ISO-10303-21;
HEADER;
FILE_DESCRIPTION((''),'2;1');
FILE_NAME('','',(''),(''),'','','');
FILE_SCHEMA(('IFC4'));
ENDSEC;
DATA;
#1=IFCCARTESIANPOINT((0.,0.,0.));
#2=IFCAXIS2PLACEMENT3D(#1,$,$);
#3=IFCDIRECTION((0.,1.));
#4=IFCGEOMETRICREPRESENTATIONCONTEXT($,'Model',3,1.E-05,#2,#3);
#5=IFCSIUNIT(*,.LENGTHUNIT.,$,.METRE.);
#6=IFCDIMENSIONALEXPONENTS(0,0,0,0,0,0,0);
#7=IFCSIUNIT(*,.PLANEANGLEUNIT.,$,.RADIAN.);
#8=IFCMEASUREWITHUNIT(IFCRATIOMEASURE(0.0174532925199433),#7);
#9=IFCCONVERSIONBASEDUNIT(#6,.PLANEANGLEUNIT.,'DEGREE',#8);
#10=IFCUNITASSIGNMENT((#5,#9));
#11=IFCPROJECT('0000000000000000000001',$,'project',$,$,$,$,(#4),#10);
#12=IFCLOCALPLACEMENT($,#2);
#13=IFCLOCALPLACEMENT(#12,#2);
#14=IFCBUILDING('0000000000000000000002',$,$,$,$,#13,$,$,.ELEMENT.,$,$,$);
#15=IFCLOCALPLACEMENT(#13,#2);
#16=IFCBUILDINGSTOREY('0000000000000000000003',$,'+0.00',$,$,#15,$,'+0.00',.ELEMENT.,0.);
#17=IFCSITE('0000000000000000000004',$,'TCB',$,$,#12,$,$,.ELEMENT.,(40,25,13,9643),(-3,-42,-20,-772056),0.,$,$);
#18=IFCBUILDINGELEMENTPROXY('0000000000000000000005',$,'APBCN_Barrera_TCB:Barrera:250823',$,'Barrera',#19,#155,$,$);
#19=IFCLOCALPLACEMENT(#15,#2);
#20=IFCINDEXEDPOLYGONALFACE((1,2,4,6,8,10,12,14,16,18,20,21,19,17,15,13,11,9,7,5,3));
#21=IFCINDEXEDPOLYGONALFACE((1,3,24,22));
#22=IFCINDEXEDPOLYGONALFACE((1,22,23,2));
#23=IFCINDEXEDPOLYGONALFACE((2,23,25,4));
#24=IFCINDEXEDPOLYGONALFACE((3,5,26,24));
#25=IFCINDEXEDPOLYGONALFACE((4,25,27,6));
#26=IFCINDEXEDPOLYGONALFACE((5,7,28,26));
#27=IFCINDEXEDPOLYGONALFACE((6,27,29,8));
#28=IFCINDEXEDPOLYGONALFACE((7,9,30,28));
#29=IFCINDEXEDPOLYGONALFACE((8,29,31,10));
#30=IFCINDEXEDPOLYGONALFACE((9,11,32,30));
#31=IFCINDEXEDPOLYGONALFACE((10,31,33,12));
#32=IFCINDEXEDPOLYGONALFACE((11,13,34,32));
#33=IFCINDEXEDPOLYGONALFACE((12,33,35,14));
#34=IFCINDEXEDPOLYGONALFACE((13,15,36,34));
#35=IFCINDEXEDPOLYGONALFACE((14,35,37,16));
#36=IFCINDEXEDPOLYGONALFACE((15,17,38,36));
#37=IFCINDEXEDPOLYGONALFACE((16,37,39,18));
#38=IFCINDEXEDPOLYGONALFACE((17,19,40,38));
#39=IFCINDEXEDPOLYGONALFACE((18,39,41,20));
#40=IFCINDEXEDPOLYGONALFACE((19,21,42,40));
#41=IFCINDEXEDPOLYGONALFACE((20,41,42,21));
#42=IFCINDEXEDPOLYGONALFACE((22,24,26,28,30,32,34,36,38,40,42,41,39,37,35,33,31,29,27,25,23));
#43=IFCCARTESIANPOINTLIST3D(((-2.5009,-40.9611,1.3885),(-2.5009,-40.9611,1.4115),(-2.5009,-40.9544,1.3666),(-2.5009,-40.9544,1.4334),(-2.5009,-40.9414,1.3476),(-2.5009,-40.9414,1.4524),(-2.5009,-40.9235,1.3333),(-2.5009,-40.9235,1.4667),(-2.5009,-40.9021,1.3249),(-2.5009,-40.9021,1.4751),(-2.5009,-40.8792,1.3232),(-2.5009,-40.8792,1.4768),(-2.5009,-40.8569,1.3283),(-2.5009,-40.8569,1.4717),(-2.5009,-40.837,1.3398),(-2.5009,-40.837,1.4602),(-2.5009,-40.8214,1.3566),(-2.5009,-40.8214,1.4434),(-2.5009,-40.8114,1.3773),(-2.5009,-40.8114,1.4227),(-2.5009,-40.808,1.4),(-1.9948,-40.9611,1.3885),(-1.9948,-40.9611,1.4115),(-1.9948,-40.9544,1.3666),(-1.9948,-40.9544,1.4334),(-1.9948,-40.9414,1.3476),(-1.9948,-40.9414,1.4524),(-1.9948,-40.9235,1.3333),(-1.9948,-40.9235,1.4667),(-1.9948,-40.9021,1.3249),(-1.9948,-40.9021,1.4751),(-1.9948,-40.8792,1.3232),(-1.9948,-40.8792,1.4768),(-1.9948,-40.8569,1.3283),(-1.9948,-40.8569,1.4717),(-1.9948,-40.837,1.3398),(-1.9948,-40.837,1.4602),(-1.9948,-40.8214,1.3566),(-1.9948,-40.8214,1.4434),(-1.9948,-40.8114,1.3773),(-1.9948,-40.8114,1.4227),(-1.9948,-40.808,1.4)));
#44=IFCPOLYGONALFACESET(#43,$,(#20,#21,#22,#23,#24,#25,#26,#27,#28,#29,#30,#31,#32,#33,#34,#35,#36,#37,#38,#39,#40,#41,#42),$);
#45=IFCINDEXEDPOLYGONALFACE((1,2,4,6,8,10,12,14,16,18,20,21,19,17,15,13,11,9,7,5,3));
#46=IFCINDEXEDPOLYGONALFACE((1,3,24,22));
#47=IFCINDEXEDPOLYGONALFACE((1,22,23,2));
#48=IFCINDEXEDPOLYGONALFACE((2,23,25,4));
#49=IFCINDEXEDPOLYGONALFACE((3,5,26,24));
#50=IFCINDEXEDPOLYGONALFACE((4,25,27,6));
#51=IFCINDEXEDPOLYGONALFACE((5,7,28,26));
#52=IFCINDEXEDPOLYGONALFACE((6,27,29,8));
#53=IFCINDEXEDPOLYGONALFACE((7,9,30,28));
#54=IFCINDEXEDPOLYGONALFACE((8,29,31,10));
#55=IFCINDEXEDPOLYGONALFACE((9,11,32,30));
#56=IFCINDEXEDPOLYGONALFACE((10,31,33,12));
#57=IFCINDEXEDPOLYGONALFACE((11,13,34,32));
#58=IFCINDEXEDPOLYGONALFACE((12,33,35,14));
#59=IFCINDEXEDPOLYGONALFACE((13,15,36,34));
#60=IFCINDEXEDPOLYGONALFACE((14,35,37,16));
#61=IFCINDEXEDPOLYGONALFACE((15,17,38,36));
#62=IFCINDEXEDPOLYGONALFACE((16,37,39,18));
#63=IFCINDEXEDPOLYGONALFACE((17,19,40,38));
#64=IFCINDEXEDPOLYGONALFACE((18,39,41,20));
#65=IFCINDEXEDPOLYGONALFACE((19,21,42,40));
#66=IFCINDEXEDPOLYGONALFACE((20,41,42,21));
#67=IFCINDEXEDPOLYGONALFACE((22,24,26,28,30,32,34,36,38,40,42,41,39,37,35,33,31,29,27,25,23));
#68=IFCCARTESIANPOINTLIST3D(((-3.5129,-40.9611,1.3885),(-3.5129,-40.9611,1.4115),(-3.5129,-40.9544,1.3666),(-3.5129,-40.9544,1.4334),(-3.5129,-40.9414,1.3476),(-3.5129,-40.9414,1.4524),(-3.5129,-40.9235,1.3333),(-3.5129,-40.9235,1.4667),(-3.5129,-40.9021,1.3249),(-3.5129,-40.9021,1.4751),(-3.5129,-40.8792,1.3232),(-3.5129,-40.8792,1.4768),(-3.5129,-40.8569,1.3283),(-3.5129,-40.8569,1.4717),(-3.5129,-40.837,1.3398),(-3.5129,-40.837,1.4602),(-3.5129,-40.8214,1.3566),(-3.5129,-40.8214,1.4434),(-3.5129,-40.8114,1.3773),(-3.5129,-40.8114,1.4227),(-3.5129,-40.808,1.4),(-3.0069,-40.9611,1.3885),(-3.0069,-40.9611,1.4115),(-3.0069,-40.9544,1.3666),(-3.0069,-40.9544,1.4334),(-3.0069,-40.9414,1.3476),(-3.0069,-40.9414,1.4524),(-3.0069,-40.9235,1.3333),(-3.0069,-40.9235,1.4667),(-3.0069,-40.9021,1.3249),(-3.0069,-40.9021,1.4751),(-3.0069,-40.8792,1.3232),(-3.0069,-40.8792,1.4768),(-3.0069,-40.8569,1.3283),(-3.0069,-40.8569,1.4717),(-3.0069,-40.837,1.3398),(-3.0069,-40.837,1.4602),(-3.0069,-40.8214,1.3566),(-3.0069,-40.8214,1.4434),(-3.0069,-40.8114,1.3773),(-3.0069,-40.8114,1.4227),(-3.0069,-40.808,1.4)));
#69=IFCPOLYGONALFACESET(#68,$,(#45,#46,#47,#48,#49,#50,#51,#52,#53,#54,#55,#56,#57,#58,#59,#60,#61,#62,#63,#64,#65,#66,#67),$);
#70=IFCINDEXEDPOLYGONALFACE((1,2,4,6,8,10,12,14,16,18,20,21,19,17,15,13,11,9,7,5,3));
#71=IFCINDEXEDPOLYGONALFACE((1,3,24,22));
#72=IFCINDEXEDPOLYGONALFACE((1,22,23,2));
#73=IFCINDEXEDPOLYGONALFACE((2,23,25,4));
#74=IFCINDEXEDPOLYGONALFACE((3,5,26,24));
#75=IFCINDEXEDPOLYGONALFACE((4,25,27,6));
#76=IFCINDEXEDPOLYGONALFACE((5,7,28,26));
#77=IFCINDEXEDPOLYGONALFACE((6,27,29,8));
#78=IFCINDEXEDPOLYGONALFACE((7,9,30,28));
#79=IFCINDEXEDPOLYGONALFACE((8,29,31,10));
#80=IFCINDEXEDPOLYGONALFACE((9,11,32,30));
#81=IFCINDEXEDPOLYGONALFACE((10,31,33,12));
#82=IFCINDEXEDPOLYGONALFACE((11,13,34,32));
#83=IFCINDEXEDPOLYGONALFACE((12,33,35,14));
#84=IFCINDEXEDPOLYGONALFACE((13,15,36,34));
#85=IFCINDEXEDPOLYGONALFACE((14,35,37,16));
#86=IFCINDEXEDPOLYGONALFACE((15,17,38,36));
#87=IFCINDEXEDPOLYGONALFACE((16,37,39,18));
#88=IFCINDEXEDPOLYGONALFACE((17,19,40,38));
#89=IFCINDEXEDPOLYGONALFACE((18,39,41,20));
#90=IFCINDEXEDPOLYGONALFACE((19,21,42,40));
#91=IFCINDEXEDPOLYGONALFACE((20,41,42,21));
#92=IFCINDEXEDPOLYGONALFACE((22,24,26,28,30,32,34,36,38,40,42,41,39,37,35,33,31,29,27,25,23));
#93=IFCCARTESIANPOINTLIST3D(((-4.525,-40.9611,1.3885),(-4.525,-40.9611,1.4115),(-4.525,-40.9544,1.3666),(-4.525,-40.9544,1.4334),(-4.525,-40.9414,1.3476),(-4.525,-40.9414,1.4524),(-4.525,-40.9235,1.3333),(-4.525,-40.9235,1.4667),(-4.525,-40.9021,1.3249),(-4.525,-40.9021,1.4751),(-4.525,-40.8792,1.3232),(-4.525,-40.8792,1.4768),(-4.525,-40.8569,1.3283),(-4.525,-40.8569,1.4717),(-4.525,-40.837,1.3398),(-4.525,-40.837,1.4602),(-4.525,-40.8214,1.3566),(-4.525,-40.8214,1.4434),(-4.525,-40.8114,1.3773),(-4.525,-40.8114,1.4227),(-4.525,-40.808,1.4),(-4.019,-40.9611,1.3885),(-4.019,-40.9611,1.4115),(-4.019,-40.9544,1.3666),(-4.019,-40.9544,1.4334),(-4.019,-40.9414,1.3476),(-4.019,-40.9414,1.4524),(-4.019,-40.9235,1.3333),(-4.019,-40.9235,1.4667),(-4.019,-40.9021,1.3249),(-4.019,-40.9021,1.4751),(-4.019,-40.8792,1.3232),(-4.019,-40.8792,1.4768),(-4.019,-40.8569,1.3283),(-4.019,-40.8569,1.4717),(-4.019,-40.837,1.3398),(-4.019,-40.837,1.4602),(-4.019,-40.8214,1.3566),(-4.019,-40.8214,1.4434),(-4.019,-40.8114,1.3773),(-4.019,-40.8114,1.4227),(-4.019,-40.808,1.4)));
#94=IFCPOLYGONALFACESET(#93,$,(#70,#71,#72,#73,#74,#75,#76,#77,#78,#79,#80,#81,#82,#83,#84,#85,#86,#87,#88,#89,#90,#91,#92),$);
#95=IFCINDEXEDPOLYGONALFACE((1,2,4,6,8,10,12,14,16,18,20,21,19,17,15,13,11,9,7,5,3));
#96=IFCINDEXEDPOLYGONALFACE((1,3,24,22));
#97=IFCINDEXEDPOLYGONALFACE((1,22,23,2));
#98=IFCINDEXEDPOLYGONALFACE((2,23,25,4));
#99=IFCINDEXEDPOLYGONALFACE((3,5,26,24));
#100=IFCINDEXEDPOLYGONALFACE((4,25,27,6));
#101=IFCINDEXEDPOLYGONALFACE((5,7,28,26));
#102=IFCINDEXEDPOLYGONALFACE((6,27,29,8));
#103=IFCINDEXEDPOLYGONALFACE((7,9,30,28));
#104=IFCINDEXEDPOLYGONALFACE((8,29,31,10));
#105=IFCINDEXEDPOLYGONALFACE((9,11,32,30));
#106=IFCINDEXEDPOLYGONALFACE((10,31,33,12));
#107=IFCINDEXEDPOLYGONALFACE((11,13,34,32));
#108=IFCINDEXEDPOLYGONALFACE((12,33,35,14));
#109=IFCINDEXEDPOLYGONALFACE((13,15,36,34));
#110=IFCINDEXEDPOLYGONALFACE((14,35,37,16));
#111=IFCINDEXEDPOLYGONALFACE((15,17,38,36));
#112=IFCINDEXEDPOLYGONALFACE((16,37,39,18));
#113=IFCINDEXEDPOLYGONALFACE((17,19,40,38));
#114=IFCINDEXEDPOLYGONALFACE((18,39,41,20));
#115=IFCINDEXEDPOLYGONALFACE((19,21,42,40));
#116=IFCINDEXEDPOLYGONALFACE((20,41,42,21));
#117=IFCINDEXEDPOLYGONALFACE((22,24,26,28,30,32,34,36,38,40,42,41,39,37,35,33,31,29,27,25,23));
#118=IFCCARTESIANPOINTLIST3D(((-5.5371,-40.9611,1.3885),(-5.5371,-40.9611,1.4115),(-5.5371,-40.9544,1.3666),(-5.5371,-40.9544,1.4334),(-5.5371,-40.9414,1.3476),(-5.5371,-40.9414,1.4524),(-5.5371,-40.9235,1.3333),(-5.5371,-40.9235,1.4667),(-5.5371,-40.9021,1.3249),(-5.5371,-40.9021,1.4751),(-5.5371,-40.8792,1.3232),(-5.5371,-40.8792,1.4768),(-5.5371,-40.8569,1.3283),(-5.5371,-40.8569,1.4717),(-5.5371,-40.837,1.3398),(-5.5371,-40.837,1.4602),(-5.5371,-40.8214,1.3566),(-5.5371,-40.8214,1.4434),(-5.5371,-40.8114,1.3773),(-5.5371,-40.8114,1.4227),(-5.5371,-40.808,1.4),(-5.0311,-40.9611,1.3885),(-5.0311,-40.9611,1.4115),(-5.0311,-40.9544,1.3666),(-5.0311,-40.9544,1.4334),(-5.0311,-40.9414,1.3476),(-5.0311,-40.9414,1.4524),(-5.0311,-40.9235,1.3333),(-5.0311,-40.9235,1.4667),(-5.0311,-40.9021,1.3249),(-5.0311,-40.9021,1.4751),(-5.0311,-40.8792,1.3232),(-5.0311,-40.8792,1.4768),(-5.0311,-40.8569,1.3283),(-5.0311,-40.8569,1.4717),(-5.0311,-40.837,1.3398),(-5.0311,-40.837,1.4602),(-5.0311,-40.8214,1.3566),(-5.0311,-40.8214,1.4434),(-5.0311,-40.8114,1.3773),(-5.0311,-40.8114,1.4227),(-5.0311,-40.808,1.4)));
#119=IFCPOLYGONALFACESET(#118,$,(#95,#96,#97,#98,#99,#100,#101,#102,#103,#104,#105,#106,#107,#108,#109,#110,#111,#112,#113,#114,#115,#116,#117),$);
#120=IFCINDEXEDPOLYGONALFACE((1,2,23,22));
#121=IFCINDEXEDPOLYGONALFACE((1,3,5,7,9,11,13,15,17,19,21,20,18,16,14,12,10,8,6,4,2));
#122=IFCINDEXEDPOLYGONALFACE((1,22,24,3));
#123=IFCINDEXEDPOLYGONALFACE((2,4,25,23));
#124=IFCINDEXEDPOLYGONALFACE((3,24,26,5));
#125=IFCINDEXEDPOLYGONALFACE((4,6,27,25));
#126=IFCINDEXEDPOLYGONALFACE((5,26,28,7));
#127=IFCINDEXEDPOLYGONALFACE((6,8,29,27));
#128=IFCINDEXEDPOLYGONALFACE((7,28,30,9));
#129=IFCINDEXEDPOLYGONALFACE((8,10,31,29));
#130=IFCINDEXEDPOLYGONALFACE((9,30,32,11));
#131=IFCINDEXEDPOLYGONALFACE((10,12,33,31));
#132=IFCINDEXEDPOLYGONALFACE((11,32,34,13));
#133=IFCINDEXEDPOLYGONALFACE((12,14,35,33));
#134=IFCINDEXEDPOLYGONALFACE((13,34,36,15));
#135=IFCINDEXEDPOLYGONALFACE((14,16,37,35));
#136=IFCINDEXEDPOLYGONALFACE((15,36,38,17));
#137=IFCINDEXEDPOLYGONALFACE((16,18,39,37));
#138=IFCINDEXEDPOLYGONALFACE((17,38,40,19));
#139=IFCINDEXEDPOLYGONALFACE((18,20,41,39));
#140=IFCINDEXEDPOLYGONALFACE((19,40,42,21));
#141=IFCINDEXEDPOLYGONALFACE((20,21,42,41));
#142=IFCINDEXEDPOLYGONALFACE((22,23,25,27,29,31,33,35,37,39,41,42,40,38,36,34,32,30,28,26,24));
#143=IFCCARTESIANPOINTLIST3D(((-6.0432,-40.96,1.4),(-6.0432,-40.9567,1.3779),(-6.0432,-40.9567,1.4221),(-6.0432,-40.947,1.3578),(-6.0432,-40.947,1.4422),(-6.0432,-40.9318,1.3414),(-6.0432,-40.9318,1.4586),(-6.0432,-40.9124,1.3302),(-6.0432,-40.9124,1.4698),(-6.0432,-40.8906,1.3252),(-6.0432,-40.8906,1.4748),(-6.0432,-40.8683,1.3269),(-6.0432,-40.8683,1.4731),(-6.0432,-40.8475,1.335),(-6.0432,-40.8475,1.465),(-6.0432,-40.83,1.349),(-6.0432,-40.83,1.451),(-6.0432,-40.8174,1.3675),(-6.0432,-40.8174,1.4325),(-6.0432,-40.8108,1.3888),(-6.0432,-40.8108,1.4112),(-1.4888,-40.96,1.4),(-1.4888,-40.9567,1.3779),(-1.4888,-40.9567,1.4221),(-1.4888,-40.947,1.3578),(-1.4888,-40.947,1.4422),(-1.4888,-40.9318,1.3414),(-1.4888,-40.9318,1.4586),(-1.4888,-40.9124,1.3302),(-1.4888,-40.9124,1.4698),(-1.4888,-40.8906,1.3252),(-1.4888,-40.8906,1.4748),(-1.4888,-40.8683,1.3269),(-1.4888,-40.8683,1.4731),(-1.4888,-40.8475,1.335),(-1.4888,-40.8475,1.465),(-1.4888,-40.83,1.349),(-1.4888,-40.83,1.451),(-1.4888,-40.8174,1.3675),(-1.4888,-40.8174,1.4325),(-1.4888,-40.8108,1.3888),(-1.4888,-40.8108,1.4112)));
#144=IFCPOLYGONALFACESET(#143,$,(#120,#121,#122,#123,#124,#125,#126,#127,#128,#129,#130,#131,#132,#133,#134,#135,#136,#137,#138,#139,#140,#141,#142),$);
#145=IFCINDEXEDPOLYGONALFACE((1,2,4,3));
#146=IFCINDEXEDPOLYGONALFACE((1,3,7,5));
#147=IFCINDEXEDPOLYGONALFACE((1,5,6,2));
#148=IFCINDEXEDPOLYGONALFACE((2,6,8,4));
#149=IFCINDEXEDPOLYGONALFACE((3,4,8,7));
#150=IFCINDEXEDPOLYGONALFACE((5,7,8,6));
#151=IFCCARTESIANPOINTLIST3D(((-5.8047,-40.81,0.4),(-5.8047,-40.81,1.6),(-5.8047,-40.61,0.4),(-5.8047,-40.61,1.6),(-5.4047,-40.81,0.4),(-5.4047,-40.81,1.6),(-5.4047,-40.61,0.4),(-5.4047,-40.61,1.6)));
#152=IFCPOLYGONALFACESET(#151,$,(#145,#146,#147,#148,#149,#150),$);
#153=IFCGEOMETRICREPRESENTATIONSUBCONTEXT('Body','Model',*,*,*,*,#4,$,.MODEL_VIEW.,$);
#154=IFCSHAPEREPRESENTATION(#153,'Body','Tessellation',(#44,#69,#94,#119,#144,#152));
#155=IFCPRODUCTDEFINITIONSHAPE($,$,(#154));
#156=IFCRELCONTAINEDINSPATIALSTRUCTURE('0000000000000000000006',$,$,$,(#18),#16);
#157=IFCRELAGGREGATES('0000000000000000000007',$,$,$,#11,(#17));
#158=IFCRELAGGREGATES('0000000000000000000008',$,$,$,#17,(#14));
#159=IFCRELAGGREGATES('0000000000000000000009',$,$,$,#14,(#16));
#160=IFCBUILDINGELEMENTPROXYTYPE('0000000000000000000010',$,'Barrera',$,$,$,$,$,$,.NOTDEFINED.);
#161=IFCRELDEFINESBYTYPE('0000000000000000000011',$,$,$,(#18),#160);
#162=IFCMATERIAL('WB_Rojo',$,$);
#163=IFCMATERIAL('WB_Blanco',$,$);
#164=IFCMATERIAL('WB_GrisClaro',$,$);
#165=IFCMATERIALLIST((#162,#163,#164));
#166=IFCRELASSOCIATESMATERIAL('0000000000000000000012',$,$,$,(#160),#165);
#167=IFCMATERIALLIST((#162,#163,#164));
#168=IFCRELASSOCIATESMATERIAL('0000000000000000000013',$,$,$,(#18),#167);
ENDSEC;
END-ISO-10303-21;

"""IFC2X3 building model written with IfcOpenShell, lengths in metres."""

from ifc_helpers import new_model, entity, si_unit, converted_unit, direction, frame, frame_2d, origin, place, context, subcontext, project, spatial, rectangle, circle, extrude, source, transform, mapped, material, material_list, type_object, type_shapes, element, save


model = new_model("IFC2X3")

# Units and contexts
model_context = context("Model", 3, precision=1e-05, world=origin(), true_north=direction((0.0, 1.0)))
body_context = subcontext(model_context, "Body", "Model", "MODEL_VIEW")
ifc_project = project(units=[si_unit("LENGTHUNIT", "METRE"), converted_unit("PLANEANGLEUNIT", "DEGREE", entity("IfcRatioMeasure", 0.0174532925199433), si_unit("PLANEANGLEUNIT", "RADIAN"), dimensions=[0, 0, 0, 0, 0, 0, 0])], contexts=[model_context])

# Site, building, storey
site_placement = place(None, origin())
site = spatial("IfcSite", under=ifc_project, at=site_placement, Name="TCB", CompositionType="ELEMENT", RefLatitude=(40, 25, 13, 9643), RefLongitude=(-3, -42, -20, -772056), RefElevation=0.0)
building_placement = place(site_placement, origin())
building = spatial("IfcBuilding", under=site, at=building_placement, CompositionType="ELEMENT")
storey_placement = place(building_placement, origin())
storey = spatial("IfcBuildingStorey", under=building, at=storey_placement, Name="+0.00", LongName="+0.00", CompositionType="ELEMENT", Elevation=0.0)

# Shared definitions
ifc_material_1 = material(Name="WB_GrisClaro")

# Building element proxy
ifc_material_2 = material(Name="WB_Rojo")
ifc_material_3 = material(Name="WB_Blanco")
ifc_material_list_1 = material_list([ifc_material_2, ifc_material_3, ifc_material_1])
building_element_proxy_type_1 = type_object("IfcBuildingElementProxyType", Name="Barrera", PredefinedType="NOTDEFINED", material=ifc_material_list_1)
shared_shape_1 = source(origin(), body_context, "Body", "SweptSolid", [
    extrude(circle(Radius=0.077, at=frame_2d((0.0, 0.0), x_axis=(1.0, 0.0))), frame((2.8039, -0.175, 1.0), z_axis=(1.0, 0.0, 0.0), x_axis=(0.0, 1.0, 0.0)), (0.0, 0.0, 1.0), 0.506),
    extrude(circle(Radius=0.077, at=frame_2d((0.0, 0.0), x_axis=(1.0, 0.0))), frame((1.7918, -0.175, 1.0), z_axis=(1.0, 0.0, 0.0), x_axis=(0.0, 1.0, 0.0)), (0.0, 0.0, 1.0), 0.506),
    extrude(circle(Radius=0.077, at=frame_2d((0.0, 0.0), x_axis=(1.0, 0.0))), frame((0.7797, -0.175, 1.0), z_axis=(1.0, 0.0, 0.0), x_axis=(0.0, 1.0, 0.0)), (0.0, 0.0, 1.0), 0.506),
    extrude(circle(Radius=0.077, at=frame_2d((0.0, 0.0), x_axis=(1.0, 0.0))), frame((-0.2324, -0.175, 1.0), z_axis=(1.0, 0.0, 0.0), x_axis=(0.0, 1.0, 0.0)), (0.0, 0.0, 1.0), 0.506),
    extrude(circle(Radius=0.075, at=frame_2d((0.0, 0.0), x_axis=(1.0, 0.0))), frame((-0.7385, -0.175, 1.0), z_axis=(1.0, 0.0, 0.0), x_axis=(0.0, -1.0, 0.0)), (0.0, 0.0, 1.0), 4.5544),
    extrude(rectangle(XDim=0.2, YDim=0.4, at=frame_2d((0.0, 0.0), x_axis=(1.0, 0.0))), frame((-0.3, 0.0, 0.0), z_axis=(0.0, 0.0, 1.0), x_axis=(0.0, -1.0, 0.0)), (0.0, 0.0, 1.0), 1.2),
])
type_shapes(building_element_proxy_type_1, [shared_shape_1])
ifc_material_list_2 = material_list([ifc_material_2, ifc_material_3, ifc_material_1])
proxy_1_placement = place(storey_placement, frame((-5.3047, -40.71, 0.4)))
element("IfcBuildingElementProxy", 1, at=proxy_1_placement, inside=storey, type_object=building_element_proxy_type_1, material=ifc_material_list_2, Name="APBCN_Barrera_TCB:Barrera:250823", ObjectType="Barrera", context=body_context, shape_type="MappedRepresentation", body=[
    mapped(shared_shape_1, transform((0.0, 0.0, 0.0), scale=1.0)),
])

save(model, "model.ifc")
